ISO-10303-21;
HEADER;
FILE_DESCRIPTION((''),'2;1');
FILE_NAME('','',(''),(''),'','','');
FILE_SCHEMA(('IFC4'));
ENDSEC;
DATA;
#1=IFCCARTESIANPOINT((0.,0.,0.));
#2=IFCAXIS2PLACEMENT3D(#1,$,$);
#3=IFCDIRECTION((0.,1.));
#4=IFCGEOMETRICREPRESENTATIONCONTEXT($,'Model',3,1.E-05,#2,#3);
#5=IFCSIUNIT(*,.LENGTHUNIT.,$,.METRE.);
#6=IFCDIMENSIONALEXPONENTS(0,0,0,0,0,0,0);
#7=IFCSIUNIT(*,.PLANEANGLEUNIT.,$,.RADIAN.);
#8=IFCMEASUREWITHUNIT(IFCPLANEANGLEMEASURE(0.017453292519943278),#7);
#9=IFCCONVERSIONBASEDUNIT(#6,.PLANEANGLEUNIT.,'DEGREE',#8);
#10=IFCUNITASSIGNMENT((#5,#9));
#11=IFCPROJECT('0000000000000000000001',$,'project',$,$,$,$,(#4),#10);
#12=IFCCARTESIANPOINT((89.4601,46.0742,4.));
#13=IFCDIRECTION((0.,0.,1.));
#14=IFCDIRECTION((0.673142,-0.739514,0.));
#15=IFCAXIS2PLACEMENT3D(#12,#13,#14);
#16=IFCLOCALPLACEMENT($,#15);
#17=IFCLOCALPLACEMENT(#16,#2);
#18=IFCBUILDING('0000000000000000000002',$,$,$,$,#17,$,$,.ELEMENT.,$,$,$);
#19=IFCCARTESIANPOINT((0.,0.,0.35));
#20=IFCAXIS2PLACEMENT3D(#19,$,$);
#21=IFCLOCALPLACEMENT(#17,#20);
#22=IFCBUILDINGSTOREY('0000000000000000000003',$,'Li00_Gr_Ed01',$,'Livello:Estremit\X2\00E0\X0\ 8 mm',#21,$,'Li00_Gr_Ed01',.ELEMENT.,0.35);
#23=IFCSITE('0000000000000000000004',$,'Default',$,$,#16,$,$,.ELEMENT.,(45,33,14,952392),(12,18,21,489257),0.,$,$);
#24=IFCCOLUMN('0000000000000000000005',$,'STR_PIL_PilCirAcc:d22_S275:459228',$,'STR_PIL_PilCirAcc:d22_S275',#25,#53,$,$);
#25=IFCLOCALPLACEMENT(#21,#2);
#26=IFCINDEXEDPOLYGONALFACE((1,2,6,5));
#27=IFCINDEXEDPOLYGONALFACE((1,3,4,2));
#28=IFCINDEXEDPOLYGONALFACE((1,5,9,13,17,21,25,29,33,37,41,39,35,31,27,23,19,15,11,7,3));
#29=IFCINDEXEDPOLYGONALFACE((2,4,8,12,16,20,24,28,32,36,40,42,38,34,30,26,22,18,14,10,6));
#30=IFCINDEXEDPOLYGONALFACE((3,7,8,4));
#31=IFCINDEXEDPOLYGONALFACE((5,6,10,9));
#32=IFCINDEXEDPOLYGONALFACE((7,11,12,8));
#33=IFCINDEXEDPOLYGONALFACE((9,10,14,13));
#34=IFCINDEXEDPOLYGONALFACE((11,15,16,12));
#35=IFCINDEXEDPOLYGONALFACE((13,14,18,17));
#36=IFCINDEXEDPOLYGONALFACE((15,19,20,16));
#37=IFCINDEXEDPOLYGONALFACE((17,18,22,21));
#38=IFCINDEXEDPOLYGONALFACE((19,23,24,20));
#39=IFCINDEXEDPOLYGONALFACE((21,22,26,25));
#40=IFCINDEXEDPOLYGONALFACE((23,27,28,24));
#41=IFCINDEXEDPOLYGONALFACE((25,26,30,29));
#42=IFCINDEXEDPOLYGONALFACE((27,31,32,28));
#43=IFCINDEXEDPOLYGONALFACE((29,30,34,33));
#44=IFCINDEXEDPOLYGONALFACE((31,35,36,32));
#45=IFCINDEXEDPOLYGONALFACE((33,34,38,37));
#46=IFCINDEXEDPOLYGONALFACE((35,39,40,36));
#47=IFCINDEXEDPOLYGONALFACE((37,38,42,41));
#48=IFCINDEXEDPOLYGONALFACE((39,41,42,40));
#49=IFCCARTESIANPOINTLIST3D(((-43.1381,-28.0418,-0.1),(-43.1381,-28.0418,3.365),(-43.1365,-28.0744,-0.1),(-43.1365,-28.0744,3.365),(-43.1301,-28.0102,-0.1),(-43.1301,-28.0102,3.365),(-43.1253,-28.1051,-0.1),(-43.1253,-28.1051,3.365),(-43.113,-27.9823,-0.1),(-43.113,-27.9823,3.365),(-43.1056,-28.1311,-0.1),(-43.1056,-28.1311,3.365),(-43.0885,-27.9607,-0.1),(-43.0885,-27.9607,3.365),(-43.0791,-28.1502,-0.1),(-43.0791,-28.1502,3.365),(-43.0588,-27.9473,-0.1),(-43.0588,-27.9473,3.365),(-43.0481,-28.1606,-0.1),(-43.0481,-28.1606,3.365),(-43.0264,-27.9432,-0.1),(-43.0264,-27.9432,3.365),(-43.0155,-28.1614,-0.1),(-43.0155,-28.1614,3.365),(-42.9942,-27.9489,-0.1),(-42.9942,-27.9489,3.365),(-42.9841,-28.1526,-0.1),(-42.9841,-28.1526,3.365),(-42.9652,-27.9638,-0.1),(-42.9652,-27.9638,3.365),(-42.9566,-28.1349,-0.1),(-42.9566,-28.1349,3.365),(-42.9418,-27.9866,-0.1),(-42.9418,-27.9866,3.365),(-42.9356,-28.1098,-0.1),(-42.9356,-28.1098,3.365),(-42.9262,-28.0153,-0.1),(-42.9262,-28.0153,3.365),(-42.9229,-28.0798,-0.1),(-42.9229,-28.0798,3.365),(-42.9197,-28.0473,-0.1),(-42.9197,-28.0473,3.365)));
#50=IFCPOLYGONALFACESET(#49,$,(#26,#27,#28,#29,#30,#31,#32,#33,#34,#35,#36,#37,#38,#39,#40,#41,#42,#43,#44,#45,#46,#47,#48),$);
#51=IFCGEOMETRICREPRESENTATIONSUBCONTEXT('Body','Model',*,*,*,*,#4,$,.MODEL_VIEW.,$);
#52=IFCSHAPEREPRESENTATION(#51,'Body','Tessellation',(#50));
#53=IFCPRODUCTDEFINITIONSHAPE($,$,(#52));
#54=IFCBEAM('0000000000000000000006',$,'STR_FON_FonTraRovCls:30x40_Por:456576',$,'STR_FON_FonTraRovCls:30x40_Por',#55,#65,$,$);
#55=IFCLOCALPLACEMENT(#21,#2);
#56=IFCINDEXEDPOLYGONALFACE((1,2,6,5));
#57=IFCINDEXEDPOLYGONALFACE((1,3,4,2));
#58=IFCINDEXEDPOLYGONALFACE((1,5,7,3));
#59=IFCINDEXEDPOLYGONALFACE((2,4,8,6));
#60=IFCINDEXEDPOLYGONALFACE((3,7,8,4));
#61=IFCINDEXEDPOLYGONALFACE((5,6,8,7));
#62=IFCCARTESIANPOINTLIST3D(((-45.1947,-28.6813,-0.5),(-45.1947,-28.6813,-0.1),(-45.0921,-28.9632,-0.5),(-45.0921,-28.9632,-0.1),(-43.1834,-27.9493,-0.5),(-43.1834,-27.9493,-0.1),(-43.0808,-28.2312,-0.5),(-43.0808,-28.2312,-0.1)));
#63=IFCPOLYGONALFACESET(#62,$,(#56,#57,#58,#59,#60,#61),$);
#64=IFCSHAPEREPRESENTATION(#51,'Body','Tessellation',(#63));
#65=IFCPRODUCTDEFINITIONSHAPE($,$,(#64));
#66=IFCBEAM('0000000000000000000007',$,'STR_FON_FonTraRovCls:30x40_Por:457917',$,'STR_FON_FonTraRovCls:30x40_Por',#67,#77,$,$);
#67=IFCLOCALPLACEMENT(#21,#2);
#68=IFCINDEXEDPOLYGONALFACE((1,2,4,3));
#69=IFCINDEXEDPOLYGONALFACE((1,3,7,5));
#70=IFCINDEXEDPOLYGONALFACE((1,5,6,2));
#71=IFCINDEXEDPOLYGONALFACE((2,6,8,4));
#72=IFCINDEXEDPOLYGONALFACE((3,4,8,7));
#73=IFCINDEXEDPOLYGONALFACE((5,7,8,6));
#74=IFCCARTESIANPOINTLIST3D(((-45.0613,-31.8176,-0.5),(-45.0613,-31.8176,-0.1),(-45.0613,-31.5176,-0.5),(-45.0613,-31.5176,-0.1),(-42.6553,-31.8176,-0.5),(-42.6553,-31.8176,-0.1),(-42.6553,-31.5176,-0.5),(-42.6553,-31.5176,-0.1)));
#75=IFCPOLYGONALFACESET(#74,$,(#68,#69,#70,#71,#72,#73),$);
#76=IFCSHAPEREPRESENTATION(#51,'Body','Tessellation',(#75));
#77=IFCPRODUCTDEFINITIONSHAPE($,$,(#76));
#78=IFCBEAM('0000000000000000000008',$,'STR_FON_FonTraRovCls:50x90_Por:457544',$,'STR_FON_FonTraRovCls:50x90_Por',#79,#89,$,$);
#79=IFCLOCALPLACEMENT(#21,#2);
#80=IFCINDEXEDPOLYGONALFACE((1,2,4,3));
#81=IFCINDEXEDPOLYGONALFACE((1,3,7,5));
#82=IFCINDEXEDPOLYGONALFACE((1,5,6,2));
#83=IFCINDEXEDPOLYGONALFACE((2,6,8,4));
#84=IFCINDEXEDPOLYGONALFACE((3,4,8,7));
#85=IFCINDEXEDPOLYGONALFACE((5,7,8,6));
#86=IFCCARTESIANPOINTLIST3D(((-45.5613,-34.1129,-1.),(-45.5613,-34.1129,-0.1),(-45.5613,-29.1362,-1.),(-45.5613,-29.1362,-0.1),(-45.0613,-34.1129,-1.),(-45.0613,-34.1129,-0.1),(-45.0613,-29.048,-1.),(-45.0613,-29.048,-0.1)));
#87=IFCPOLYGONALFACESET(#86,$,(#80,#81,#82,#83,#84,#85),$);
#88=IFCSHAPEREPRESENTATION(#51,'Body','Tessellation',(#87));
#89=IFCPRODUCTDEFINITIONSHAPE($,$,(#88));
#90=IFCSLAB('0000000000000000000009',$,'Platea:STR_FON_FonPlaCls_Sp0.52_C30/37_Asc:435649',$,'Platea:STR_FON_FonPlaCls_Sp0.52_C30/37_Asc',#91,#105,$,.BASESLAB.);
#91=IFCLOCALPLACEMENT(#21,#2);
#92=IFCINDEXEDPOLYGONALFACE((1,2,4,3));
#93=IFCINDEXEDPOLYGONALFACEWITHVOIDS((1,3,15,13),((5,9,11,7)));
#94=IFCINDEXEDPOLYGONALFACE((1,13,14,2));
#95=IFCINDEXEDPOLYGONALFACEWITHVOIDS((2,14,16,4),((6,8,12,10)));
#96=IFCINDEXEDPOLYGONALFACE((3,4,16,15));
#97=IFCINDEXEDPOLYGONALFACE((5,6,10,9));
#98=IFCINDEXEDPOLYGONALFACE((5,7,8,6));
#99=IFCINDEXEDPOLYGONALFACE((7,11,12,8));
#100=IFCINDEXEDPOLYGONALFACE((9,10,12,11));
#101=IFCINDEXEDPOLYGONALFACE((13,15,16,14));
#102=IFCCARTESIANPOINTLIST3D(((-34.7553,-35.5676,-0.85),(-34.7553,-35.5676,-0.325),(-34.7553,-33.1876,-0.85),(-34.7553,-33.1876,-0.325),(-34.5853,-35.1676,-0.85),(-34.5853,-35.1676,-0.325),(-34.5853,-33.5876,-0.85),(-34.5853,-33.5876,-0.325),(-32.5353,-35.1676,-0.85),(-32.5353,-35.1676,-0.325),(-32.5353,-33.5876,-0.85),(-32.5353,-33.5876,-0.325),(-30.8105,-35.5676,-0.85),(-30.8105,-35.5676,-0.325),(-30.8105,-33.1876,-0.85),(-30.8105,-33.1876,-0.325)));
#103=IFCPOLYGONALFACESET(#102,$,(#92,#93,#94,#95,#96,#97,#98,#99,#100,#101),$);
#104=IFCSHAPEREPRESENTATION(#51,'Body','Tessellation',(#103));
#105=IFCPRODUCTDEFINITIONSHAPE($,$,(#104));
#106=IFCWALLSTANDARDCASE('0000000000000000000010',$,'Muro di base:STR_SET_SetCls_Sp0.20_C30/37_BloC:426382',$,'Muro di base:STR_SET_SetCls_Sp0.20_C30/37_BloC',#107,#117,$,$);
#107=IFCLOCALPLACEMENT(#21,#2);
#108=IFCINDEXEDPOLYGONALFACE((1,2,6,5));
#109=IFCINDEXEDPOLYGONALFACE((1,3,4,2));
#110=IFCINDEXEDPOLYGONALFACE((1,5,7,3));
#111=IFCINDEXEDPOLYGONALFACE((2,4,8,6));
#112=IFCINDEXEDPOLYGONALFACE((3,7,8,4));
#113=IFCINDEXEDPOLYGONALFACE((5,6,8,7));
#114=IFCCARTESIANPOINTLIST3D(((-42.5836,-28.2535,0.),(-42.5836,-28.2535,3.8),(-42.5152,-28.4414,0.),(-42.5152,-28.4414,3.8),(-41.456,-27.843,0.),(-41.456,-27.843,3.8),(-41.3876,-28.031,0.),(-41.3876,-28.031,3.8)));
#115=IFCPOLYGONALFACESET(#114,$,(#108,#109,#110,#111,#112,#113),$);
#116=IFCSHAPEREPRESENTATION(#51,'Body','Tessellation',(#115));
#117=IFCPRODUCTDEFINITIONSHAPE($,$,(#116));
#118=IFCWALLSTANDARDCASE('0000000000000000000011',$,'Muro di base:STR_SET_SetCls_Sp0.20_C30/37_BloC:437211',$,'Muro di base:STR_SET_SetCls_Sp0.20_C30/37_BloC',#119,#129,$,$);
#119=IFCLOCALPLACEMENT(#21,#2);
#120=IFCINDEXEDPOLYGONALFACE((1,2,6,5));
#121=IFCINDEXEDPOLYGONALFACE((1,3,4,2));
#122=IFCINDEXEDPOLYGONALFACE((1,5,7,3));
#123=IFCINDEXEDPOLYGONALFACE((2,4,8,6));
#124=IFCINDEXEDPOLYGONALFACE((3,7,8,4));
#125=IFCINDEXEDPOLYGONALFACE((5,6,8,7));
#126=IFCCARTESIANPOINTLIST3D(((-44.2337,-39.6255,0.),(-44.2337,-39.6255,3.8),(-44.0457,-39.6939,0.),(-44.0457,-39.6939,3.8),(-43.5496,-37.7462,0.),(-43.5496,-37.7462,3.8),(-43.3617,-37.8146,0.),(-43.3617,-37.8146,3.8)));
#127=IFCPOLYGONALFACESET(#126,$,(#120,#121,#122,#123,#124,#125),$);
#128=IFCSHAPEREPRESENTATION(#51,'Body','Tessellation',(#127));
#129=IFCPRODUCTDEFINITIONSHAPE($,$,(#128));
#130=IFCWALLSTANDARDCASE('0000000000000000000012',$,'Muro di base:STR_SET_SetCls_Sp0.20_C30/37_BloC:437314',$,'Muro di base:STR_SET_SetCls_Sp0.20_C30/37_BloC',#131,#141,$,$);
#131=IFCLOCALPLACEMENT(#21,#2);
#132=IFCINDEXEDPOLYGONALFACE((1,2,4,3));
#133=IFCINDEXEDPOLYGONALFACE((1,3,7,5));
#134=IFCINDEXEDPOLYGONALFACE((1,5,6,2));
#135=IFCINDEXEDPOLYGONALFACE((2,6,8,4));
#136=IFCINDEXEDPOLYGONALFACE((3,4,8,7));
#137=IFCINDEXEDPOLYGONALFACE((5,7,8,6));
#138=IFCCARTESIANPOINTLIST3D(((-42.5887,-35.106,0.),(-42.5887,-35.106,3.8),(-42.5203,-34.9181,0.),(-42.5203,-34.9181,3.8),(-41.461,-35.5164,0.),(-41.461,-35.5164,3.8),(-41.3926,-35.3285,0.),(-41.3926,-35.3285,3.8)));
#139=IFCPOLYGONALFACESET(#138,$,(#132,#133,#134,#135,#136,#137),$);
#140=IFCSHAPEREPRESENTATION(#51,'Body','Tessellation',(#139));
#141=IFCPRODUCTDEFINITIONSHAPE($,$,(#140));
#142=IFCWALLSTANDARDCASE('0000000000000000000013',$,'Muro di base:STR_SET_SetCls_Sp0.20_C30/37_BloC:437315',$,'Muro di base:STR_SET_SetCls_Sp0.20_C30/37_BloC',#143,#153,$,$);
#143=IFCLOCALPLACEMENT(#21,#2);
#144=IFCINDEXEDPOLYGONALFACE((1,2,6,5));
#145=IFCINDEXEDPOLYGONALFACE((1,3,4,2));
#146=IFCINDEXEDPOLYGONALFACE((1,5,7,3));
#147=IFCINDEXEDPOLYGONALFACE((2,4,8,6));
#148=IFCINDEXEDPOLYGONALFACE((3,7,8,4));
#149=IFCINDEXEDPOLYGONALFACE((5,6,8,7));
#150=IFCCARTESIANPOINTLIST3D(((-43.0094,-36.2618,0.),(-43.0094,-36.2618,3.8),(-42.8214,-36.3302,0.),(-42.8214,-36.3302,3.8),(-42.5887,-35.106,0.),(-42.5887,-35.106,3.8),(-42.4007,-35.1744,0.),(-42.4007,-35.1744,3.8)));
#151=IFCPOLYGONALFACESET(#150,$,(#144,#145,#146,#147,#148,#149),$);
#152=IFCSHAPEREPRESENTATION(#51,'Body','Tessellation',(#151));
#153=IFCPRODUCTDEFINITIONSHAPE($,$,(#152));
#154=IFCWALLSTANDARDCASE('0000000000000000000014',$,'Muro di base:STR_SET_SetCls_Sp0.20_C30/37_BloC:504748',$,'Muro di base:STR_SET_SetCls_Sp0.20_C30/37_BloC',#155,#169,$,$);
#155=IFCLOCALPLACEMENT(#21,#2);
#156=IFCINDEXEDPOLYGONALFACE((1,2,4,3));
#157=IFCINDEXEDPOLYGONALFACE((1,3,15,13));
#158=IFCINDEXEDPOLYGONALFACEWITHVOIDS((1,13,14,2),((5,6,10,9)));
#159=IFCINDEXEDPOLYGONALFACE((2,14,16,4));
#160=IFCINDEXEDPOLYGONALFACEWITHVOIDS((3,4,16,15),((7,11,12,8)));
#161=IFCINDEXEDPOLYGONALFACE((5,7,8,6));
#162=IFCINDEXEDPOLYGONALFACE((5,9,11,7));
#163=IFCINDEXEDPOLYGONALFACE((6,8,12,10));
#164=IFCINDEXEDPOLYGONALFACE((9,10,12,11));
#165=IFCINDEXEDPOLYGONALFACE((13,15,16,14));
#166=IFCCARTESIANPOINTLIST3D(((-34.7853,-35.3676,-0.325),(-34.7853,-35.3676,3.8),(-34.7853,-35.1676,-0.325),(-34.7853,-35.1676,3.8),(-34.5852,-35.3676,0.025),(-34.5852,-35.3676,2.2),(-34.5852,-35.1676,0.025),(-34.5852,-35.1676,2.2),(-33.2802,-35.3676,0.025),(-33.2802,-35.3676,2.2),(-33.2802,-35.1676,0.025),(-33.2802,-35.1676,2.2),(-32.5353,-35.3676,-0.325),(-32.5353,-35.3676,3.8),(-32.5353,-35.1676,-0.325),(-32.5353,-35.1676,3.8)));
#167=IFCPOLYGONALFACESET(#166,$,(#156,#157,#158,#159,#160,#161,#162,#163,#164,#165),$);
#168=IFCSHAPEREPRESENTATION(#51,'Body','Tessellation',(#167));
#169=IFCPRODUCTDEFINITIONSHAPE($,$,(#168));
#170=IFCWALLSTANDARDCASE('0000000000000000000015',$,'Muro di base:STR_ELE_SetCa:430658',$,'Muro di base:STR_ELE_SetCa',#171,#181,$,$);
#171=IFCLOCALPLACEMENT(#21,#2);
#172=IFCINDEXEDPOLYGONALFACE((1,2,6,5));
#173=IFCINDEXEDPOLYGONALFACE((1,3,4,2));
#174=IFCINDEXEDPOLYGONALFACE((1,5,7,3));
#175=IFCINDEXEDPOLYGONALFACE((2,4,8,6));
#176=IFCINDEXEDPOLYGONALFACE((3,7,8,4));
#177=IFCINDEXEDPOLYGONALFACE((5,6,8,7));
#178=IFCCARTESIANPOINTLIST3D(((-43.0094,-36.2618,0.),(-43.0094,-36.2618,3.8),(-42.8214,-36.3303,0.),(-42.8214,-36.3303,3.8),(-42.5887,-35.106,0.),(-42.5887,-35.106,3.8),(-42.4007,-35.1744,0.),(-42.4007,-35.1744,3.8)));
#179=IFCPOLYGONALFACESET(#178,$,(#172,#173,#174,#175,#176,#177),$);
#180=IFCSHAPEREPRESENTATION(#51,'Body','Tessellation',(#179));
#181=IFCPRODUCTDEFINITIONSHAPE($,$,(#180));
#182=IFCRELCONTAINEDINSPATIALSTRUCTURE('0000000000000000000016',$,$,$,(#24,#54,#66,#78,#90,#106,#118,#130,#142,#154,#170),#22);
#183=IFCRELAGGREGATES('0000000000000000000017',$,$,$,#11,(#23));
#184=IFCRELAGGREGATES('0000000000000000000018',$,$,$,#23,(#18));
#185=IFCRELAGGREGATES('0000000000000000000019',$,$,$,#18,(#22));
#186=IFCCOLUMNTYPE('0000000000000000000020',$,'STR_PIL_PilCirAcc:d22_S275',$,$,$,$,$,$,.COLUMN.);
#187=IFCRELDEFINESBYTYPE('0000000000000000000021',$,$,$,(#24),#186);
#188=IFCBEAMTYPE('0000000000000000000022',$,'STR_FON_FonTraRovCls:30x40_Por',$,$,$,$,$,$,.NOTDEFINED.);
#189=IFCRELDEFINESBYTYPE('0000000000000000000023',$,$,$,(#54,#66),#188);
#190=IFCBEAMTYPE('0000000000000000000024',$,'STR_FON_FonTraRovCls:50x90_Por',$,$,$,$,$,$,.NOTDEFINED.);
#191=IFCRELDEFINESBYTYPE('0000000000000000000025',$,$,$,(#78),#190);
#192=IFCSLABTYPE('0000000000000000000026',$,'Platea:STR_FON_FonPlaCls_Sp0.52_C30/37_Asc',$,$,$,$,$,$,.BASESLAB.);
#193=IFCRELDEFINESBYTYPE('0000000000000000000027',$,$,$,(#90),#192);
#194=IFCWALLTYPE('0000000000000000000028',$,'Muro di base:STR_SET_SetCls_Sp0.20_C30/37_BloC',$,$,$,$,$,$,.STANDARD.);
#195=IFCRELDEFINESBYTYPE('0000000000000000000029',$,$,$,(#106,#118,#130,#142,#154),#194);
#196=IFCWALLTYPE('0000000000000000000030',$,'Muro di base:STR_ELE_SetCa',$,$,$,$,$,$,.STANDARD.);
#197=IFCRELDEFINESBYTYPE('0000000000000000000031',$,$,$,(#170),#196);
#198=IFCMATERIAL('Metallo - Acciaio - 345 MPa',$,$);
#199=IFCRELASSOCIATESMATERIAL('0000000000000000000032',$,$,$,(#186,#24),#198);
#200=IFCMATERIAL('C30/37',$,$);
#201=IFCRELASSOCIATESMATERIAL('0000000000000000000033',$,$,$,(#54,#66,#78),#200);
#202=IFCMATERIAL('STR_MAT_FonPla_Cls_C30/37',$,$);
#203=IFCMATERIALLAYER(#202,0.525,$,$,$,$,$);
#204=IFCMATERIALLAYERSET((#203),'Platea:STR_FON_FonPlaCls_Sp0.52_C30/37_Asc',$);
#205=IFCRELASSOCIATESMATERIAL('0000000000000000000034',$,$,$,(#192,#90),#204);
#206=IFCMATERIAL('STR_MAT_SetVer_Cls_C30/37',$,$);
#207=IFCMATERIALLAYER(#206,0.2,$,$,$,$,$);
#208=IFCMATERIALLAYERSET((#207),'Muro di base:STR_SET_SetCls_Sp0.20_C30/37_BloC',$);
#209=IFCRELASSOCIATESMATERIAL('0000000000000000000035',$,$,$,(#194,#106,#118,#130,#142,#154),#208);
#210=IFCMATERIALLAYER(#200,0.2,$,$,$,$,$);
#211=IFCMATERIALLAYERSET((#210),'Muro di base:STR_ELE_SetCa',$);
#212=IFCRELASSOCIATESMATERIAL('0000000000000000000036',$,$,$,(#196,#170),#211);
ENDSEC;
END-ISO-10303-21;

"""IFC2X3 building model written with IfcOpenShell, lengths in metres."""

from ifc_helpers import new_model, entity, si_unit, converted_unit, direction, frame, frame_2d, origin, origin_2d_with_axis, place, context, subcontext, project, spatial, rectangle, circle, extrude, clip, halfspace, source, transform, mapped, material, layer, layer_set, layer_usage, type_object, type_shapes, element, save


model = new_model("IFC2X3")

# Units and contexts
model_context = context("Model", 3, precision=1e-05, world=origin(), true_north=direction((0.0, 1.0)))
body_context = subcontext(model_context, "Body", "Model", "MODEL_VIEW")
ifc_project = project(units=[si_unit("LENGTHUNIT", "METRE"), converted_unit("PLANEANGLEUNIT", "DEGREE", entity("IfcPlaneAngleMeasure", 0.017453292519943278), si_unit("PLANEANGLEUNIT", "RADIAN"), dimensions=[0, 0, 0, 0, 0, 0, 0])], contexts=[model_context])

# Site, building, storey
site_placement = place(None, frame((89.4601, 46.0742, 4.0), z_axis=(0.0, 0.0, 1.0), x_axis=(0.673142, -0.739514, 0.0)))
site = spatial("IfcSite", under=ifc_project, at=site_placement, Name="Default", CompositionType="ELEMENT", RefLatitude=(45, 33, 14, 952392), RefLongitude=(12, 18, 21, 489257), RefElevation=0.0)
building_placement = place(site_placement, origin())
building = spatial("IfcBuilding", under=site, at=building_placement, CompositionType="ELEMENT")
storey_placement = place(building_placement, frame((0.0, 0.0, 0.35)))
storey = spatial("IfcBuildingStorey", under=building, at=storey_placement, Name="Li00_Gr_Ed01", ObjectType="Livello:Estremità 8 mm", LongName="Li00_Gr_Ed01", CompositionType="ELEMENT", Elevation=0.35)

# Column
ifc_material_1 = material(Name="Metallo - Acciaio - 345 MPa")
column_type = type_object("IfcColumnType", Name="STR_PIL_PilCirAcc:d22_S275", PredefinedType="COLUMN", material=ifc_material_1)
shared_shape = source(origin(), body_context, "Body", "SweptSolid", [
    extrude(circle(Radius=0.1096, at=frame_2d((0.0, 0.0), x_axis=(1.0, 0.0))), frame((0.0, 0.0, 0.25)), (0.0, 0.0, 1.0), 3.465),
])
type_shapes(column_type, [shared_shape])
column_1_placement = place(storey_placement, frame((-43.0291, -28.0527, -0.35), z_axis=(0.0, 0.0, 1.0), x_axis=(0.939693, 0.34202, 0.0)))
element("IfcColumn", 1, at=column_1_placement, inside=storey, type_object=column_type, material=ifc_material_1, Name="STR_PIL_PilCirAcc:d22_S275:459228", ObjectType="STR_PIL_PilCirAcc:d22_S275", context=body_context, shape_type="MappedRepresentation", body=[
    mapped(shared_shape, transform((0.0, 0.0, 0.0), scale=1.0)),
])

# Beams
ifc_material_2 = material(Name="C30/37")
beam_type_1 = type_object("IfcBeamType", Name="STR_FON_FonTraRovCls:30x40_Por", PredefinedType="NOTDEFINED")
beam_1_placement = place(storey_placement, frame((-45.1434, -28.8223, -0.1), z_axis=(0.0, 0.0, 1.0), x_axis=(0.939693, 0.34202, 0.0)))
element("IfcBeam", 2, at=beam_1_placement, inside=storey, type_object=beam_type_1, material=ifc_material_2, Name="STR_FON_FonTraRovCls:30x40_Por:456576", ObjectType="STR_FON_FonTraRovCls:30x40_Por", context=body_context, shape_type="SweptSolid", body=[
    extrude(rectangle(XDim=0.4, YDim=0.3, at=frame_2d((0.0, 0.0), x_axis=(1.0, 0.0))), frame((0.0, 0.0, -0.2), z_axis=(1.0, 0.0, 0.0), x_axis=(0.0, 0.0, -1.0)), (0.0, 0.0, 1.0), 2.1404),
])
beam_2_placement = place(storey_placement, frame((-42.4553, -31.6676, -0.1), z_axis=(0.0, 0.0, 1.0), x_axis=(-1.0, 0.0, 0.0)))
element("IfcBeam", 3, at=beam_2_placement, inside=storey, type_object=beam_type_1, material=ifc_material_2, Name="STR_FON_FonTraRovCls:30x40_Por:457917", ObjectType="STR_FON_FonTraRovCls:30x40_Por", context=body_context, shape_type="SweptSolid", body=[
    extrude(rectangle(XDim=0.4, YDim=0.3, at=frame_2d((0.0, 0.0), x_axis=(1.0, 0.0))), frame((0.2, 0.0, -0.2), z_axis=(1.0, 0.0, 0.0), x_axis=(0.0, 0.0, -1.0)), (0.0, 0.0, 1.0), 2.406),
])
beam_type_2 = type_object("IfcBeamType", Name="STR_FON_FonTraRovCls:50x90_Por", PredefinedType="NOTDEFINED")
beam_3_placement = place(storey_placement, frame((-45.3113, -34.3706, -0.1), z_axis=(0.0, 0.0, 1.0), x_axis=(0.0, 1.0, 0.0)))
element("IfcBeam", 4, at=beam_3_placement, inside=storey, type_object=beam_type_2, material=ifc_material_2, Name="STR_FON_FonTraRovCls:50x90_Por:457544", ObjectType="STR_FON_FonTraRovCls:50x90_Por", context=body_context, shape_type="SweptSolid", body=[
    clip(extrude(rectangle(XDim=0.9, YDim=0.5, at=frame_2d((0.0, 0.0), x_axis=(1.0, 0.0))), frame((0.2578, 0.0, -0.45), z_axis=(1.0, 0.0, 0.0), x_axis=(0.0, 0.0, -1.0)), (0.0, 0.0, 1.0), 5.0649), halfspace(frame((5.2345, 0.25, 0.0), z_axis=(0.984808, 0.173648, 0.0), x_axis=(0.173648, -0.984808, 0.0)), False)),
])

# Slab, opening
ifc_material_3 = material(Name="STR_MAT_FonPla_Cls_C30/37")
ifc_layer_1 = layer(ifc_material_3, 0.525)
ifc_layer_set_1 = layer_set([ifc_layer_1], Name="Platea:STR_FON_FonPlaCls_Sp0.52_C30/37_Asc")
ifc_layer_usage_1 = layer_usage(ifc_layer_set_1, "AXIS3", "POSITIVE", 0.0)
slab_type_1 = type_object("IfcSlabType", Name="Platea:STR_FON_FonPlaCls_Sp0.52_C30/37_Asc", PredefinedType="BASESLAB", material=ifc_layer_set_1)
slab_1_placement = place(storey_placement, frame((-34.7553, -35.5676, -0.85)))
slab_1 = element("IfcSlab", 5, at=slab_1_placement, inside=storey, type_object=slab_type_1, material=ifc_layer_usage_1, Name="Platea:STR_FON_FonPlaCls_Sp0.52_C30/37_Asc:435649", ObjectType="Platea:STR_FON_FonPlaCls_Sp0.52_C30/37_Asc", PredefinedType="BASESLAB", context=body_context, shape_type="SweptSolid", body=[
    extrude(rectangle(XDim=3.9448, YDim=2.38, at=frame_2d((0.0, 0.0), x_axis=(-1.0, 0.0))), frame((1.9724, 1.19, 0.525), z_axis=(0.0, 0.0, -1.0), x_axis=(-1.0, 0.0, 0.0)), (0.0, 0.0, 1.0), 0.525),
])
opening_1_placement = place(slab_1_placement, origin())
element("IfcOpeningElement", 6, at=opening_1_placement, cuts=slab_1, ObjectType="Opening", context=body_context, shape_type="SweptSolid", body=[
    extrude(rectangle(XDim=2.05, YDim=1.58, at=origin_2d_with_axis()), frame((1.195, 1.19, 0.0), z_axis=(0.0, 0.0, 1.0), x_axis=(-1.0, 0.0, 0.0)), (0.0, 0.0, 1.0), 0.525),
])

# Walls
ifc_material_4 = material(Name="STR_MAT_SetVer_Cls_C30/37")
ifc_layer_2 = layer(ifc_material_4, 0.2)
ifc_layer_set_2 = layer_set([ifc_layer_2], Name="Muro di base:STR_SET_SetCls_Sp0.20_C30/37_BloC")
ifc_layer_usage_2 = layer_usage(ifc_layer_set_2, "AXIS2", "NEGATIVE", 0.1)
wall_type_1 = type_object("IfcWallType", Name="Muro di base:STR_SET_SetCls_Sp0.20_C30/37_BloC", PredefinedType="STANDARD", material=ifc_layer_set_2)
wall_1_placement = place(storey_placement, frame((-42.5494, -28.3474, 0.0), z_axis=(0.0, 0.0, 1.0), x_axis=(0.939693, 0.34202, 0.0)))
element("IfcWallStandardCase", 7, at=wall_1_placement, inside=storey, type_object=wall_type_1, material=ifc_layer_usage_2, Name="Muro di base:STR_SET_SetCls_Sp0.20_C30/37_BloC:426382", ObjectType="Muro di base:STR_SET_SetCls_Sp0.20_C30/37_BloC", context=body_context, shape_type="SweptSolid", body=[
    extrude(rectangle(XDim=1.2, YDim=0.2, at=frame_2d((0.6, 0.0), x_axis=(-1.0, 0.0))), origin(), (0.0, 0.0, 1.0), 3.8),
])
wall_2_placement = place(storey_placement, frame((-44.1397, -39.6597, 0.0), z_axis=(0.0, 0.0, 1.0), x_axis=(0.34202, 0.939693, 0.0)))
element("IfcWallStandardCase", 8, at=wall_2_placement, inside=storey, type_object=wall_type_1, material=ifc_layer_usage_2, Name="Muro di base:STR_SET_SetCls_Sp0.20_C30/37_BloC:437211", ObjectType="Muro di base:STR_SET_SetCls_Sp0.20_C30/37_BloC", context=body_context, shape_type="SweptSolid", body=[
    extrude(rectangle(XDim=2.0, YDim=0.2, at=frame_2d((1.0, 0.0), x_axis=(-1.0, 0.0))), origin(), (0.0, 0.0, 1.0), 3.8),
])
wall_3_placement = place(storey_placement, frame((-41.4268, -35.4224, 0.0), z_axis=(0.0, 0.0, 1.0), x_axis=(-0.939693, 0.34202, 0.0)))
element("IfcWallStandardCase", 9, at=wall_3_placement, inside=storey, type_object=wall_type_1, material=ifc_layer_usage_2, Name="Muro di base:STR_SET_SetCls_Sp0.20_C30/37_BloC:437314", ObjectType="Muro di base:STR_SET_SetCls_Sp0.20_C30/37_BloC", context=body_context, shape_type="SweptSolid", body=[
    extrude(rectangle(XDim=1.2, YDim=0.2, at=frame_2d((0.6, 0.0), x_axis=(-1.0, 0.0))), origin(), (0.0, 0.0, 1.0), 3.8),
])
wall_4_placement = place(storey_placement, frame((-42.4947, -35.1402, 0.0), z_axis=(0.0, 0.0, 1.0), x_axis=(-0.34202, -0.939693, 0.0)))
element("IfcWallStandardCase", 10, at=wall_4_placement, inside=storey, type_object=wall_type_1, material=ifc_layer_usage_2, Name="Muro di base:STR_SET_SetCls_Sp0.20_C30/37_BloC:437315", ObjectType="Muro di base:STR_SET_SetCls_Sp0.20_C30/37_BloC", context=body_context, shape_type="SweptSolid", body=[
    extrude(rectangle(XDim=1.23, YDim=0.2, at=frame_2d((0.615, 0.0), x_axis=(-1.0, 0.0))), origin(), (0.0, 0.0, 1.0), 3.8),
])

# Wall, opening
wall_5_placement = place(storey_placement, frame((-34.7853, -35.2676, -0.325)))
wall_5 = element("IfcWallStandardCase", 11, at=wall_5_placement, inside=storey, type_object=wall_type_1, material=ifc_layer_usage_2, Name="Muro di base:STR_SET_SetCls_Sp0.20_C30/37_BloC:504748", ObjectType="Muro di base:STR_SET_SetCls_Sp0.20_C30/37_BloC", context=body_context, shape_type="SweptSolid", body=[
    extrude(rectangle(XDim=2.25, YDim=0.2, at=frame_2d((1.125, 0.0), x_axis=(-1.0, 0.0))), origin(), (0.0, 0.0, 1.0), 4.125),
])
opening_2_placement = place(wall_5_placement, origin())
element("IfcOpeningElement", 12, at=opening_2_placement, cuts=wall_5, ObjectType="Opening", context=body_context, shape_type="SweptSolid", body=[
    extrude(rectangle(XDim=2.175, YDim=1.305, at=origin_2d_with_axis()), frame((0.8525, 0.1, 1.4375), z_axis=(0.0, -1.0, 0.0), x_axis=(0.0, 0.0, -1.0)), (0.0, 0.0, 1.0), 0.2),
])

# Wall
ifc_layer_3 = layer(ifc_material_2, 0.2)
ifc_layer_set_3 = layer_set([ifc_layer_3], Name="Muro di base:STR_ELE_SetCa")
ifc_layer_usage_3 = layer_usage(ifc_layer_set_3, "AXIS2", "NEGATIVE", 0.1)
wall_type_2 = type_object("IfcWallType", Name="Muro di base:STR_ELE_SetCa", PredefinedType="STANDARD", material=ifc_layer_set_3)
wall_6_placement = place(storey_placement, frame((-42.9154, -36.296, 0.0), z_axis=(0.0, 0.0, 1.0), x_axis=(0.34202, 0.939693, 0.0)))
element("IfcWallStandardCase", 13, at=wall_6_placement, inside=storey, type_object=wall_type_2, material=ifc_layer_usage_3, Name="Muro di base:STR_ELE_SetCa:430658", ObjectType="Muro di base:STR_ELE_SetCa", context=body_context, shape_type="SweptSolid", body=[
    extrude(rectangle(XDim=1.23, YDim=0.2, at=frame_2d((0.615, 0.0), x_axis=(-1.0, 0.0))), origin(), (0.0, 0.0, 1.0), 3.8),
])

save(model, "model.ifc")
